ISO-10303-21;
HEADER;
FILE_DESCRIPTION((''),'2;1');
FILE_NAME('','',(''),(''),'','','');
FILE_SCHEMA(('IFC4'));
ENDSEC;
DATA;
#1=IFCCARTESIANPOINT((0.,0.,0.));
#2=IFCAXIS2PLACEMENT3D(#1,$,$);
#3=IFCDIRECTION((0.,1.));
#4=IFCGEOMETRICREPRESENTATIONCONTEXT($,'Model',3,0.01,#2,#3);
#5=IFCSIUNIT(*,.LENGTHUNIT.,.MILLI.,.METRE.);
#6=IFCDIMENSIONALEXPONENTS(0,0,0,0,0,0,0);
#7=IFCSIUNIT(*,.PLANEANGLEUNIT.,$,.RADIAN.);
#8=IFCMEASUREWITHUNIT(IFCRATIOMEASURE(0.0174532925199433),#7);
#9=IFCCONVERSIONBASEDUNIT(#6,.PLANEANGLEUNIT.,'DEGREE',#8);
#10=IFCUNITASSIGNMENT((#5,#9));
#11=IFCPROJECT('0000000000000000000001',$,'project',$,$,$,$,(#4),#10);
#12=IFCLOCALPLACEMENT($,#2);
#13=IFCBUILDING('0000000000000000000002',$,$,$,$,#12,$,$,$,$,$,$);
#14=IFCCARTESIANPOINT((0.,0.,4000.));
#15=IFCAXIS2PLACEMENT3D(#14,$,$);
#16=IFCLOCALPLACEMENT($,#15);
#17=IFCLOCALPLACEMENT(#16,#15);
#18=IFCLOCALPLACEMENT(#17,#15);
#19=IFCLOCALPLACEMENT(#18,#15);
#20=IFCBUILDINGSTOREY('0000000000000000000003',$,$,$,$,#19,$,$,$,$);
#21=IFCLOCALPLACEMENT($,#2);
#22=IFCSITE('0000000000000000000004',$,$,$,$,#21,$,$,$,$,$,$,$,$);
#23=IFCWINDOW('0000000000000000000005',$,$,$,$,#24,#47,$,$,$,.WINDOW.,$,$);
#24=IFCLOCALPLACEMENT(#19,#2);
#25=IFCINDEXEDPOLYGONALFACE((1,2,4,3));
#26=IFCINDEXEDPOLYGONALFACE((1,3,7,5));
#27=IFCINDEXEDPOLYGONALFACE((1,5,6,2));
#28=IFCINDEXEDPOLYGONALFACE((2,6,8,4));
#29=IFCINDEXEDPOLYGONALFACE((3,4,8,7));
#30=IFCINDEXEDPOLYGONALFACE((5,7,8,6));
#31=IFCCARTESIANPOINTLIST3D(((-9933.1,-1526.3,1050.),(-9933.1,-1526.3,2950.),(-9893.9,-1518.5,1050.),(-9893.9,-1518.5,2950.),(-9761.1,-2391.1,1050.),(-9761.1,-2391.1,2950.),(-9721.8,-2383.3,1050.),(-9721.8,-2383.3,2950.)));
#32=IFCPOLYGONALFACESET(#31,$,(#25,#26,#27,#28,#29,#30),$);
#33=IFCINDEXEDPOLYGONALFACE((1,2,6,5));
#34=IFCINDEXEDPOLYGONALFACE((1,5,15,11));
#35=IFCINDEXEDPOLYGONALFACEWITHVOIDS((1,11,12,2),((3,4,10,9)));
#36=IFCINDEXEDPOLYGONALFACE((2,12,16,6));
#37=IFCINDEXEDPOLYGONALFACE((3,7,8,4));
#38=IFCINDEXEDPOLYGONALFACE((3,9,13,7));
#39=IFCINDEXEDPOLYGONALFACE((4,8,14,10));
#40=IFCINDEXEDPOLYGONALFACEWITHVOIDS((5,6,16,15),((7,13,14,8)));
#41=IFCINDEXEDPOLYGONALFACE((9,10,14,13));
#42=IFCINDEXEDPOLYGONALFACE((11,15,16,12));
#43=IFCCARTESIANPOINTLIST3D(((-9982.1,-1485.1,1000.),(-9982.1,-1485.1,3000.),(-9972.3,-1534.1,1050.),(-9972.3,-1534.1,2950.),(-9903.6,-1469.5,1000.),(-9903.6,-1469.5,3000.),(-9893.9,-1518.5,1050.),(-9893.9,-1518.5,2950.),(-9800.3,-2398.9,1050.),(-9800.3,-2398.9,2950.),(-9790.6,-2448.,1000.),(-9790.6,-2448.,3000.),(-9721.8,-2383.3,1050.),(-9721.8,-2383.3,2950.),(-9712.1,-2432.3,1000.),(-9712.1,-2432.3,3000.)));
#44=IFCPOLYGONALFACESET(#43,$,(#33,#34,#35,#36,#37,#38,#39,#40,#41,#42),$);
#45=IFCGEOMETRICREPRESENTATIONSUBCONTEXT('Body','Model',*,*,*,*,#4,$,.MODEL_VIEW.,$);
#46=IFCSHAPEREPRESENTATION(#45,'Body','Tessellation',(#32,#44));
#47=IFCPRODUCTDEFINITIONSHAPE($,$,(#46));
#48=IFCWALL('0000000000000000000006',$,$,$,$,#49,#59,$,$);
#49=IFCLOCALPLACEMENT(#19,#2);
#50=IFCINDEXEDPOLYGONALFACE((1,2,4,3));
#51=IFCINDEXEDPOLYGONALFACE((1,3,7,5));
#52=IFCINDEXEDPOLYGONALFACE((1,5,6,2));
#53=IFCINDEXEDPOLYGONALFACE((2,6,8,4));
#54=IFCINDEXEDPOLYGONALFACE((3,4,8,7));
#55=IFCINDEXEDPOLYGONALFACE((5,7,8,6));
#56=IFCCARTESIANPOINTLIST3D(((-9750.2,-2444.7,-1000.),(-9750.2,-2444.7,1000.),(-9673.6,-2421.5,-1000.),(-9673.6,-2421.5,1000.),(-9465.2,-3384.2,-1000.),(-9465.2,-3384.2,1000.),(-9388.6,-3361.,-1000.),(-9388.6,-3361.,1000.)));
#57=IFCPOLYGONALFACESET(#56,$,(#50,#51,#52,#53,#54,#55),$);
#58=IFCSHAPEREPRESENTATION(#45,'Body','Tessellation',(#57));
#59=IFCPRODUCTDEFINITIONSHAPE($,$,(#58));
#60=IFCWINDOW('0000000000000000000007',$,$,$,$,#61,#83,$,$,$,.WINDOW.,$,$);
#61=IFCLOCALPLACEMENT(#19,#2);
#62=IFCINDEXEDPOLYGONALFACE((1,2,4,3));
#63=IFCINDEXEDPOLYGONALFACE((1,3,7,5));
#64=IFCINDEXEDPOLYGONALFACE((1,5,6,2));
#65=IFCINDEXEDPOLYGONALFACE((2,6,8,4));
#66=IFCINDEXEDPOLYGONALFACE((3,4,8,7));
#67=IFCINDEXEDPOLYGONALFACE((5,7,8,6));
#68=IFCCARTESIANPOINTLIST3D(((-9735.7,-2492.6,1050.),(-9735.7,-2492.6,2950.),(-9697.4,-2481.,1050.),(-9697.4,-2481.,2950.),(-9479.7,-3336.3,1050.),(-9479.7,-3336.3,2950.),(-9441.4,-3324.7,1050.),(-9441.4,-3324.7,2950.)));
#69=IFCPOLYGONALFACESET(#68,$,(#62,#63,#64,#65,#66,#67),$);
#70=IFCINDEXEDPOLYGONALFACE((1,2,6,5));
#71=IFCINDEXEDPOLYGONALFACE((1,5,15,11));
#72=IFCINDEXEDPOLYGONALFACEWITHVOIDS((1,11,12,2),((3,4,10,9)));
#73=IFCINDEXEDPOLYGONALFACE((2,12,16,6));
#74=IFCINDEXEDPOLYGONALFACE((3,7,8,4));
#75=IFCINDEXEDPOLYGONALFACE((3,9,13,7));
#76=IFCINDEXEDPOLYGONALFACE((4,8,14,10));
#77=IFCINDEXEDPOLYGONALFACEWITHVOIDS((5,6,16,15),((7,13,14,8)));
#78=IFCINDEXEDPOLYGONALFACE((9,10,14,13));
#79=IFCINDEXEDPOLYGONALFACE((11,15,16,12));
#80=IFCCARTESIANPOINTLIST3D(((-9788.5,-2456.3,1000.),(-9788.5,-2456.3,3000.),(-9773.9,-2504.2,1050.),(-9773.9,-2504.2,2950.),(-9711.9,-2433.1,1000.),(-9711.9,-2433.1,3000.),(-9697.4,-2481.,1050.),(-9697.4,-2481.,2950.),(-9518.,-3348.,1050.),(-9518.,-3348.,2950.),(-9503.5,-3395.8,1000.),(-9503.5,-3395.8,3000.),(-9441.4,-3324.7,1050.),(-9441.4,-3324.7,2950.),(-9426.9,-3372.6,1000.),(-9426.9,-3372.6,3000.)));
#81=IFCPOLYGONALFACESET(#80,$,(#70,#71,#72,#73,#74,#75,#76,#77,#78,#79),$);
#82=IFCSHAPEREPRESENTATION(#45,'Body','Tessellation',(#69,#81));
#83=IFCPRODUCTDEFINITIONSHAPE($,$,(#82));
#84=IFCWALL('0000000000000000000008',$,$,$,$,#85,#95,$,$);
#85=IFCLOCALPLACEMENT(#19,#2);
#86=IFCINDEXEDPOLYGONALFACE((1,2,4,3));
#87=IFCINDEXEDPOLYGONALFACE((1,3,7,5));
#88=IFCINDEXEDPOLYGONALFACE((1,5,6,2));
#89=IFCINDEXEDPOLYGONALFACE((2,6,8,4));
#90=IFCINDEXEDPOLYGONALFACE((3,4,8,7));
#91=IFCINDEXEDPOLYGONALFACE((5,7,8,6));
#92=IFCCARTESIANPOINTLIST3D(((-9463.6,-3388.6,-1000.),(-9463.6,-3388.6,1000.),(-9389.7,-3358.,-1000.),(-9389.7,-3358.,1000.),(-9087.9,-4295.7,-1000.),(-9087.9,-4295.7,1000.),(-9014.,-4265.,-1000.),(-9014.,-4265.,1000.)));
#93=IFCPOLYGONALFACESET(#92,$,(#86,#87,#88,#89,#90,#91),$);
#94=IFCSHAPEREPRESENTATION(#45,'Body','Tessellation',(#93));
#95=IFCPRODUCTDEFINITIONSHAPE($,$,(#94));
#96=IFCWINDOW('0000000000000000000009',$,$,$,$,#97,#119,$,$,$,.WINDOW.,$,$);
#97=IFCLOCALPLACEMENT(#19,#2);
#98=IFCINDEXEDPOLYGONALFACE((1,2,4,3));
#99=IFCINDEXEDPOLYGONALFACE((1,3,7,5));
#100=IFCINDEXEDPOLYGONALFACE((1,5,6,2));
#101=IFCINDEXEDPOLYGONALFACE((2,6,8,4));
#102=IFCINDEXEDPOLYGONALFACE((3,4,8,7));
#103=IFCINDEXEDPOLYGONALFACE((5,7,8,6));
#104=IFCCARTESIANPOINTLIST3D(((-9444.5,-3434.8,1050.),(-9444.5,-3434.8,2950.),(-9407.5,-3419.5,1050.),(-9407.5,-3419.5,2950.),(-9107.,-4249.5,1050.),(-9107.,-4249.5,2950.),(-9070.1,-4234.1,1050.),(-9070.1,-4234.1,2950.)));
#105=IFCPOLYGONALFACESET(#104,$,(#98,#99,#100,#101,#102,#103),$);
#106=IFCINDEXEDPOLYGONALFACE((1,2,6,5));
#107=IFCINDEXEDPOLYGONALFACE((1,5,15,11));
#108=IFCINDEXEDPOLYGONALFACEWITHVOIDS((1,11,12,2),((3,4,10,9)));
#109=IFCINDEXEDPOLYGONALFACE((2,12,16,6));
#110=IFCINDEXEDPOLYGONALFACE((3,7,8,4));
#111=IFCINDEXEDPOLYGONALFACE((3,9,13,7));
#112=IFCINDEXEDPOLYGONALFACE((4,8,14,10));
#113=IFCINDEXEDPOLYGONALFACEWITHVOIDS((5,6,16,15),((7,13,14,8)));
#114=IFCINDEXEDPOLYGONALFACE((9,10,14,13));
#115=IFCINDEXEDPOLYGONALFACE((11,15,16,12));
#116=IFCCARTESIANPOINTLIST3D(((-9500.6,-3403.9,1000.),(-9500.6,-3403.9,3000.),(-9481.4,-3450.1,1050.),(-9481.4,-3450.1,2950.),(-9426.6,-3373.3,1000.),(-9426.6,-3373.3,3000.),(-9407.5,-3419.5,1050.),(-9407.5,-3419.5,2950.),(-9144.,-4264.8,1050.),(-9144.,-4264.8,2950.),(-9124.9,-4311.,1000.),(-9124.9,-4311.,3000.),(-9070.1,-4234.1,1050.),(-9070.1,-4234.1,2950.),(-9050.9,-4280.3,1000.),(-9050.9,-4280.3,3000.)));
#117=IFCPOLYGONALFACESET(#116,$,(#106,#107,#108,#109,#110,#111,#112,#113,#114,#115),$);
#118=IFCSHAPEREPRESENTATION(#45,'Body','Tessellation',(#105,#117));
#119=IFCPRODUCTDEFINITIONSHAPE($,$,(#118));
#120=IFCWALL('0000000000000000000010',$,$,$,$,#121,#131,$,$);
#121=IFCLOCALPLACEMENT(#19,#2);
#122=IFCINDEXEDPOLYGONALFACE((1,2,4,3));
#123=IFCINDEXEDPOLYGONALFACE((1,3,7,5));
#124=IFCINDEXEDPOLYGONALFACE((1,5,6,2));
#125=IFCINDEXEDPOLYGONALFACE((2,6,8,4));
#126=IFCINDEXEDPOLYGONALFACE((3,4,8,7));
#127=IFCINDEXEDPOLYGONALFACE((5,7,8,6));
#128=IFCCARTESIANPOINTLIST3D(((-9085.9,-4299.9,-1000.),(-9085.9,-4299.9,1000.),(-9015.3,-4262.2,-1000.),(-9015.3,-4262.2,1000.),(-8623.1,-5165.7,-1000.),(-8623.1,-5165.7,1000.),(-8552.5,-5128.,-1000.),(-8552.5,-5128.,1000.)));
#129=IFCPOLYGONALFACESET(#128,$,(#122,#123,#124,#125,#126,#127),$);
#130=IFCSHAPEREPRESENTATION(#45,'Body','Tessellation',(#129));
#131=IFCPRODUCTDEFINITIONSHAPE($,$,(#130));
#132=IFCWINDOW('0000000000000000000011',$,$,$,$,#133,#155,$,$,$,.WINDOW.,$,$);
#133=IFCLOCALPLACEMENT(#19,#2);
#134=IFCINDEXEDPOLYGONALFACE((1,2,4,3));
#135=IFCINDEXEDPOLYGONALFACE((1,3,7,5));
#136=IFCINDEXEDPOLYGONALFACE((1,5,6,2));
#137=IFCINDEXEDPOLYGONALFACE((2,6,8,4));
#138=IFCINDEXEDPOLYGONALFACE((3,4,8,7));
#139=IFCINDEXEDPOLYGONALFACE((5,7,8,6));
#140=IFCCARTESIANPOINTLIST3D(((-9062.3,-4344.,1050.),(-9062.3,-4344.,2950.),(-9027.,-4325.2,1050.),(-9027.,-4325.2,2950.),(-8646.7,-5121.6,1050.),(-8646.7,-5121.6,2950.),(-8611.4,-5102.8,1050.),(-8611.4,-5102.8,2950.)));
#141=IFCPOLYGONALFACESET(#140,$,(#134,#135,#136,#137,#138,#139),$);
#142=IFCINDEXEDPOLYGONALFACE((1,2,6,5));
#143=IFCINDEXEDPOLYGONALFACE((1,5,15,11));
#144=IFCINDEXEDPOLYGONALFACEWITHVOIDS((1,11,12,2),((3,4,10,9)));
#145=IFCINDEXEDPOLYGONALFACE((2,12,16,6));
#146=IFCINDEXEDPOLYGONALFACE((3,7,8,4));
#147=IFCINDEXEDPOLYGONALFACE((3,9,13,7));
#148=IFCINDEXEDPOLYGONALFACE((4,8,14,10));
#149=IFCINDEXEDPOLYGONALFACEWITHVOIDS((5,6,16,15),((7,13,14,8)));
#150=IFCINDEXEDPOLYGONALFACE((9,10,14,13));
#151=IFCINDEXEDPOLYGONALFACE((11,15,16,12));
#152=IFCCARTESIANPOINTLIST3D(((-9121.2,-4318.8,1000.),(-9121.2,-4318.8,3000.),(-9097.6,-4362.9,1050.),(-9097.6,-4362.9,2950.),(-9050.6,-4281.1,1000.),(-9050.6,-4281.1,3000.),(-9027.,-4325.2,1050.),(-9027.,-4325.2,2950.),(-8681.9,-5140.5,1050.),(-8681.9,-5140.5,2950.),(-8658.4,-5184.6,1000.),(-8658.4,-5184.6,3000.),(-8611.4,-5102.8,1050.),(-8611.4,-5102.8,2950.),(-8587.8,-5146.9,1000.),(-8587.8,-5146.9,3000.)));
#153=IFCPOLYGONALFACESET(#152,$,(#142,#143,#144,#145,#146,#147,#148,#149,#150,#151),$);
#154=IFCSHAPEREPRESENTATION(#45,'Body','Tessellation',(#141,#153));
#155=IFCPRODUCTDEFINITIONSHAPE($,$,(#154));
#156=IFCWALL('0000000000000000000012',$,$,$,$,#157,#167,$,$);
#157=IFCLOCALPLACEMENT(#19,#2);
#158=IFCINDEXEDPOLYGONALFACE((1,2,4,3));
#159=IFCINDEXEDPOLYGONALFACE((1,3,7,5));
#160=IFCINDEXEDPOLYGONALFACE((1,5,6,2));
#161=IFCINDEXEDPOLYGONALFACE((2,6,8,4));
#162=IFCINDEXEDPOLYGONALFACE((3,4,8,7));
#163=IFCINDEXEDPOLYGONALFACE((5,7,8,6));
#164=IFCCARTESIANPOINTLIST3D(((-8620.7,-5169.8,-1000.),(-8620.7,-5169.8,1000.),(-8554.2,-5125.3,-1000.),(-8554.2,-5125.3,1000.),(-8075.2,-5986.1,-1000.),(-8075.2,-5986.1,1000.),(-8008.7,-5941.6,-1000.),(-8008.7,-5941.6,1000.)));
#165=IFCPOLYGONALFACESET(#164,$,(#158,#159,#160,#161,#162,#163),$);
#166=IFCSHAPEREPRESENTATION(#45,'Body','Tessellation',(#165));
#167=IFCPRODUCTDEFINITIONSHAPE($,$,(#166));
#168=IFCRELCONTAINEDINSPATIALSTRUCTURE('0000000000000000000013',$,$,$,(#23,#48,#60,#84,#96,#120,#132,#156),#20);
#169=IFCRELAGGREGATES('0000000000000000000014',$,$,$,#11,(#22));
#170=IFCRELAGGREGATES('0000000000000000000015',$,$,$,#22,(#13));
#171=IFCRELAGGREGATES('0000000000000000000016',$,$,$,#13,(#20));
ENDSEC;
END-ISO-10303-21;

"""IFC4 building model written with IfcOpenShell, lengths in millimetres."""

from ifc_helpers import new_model, entity, si_unit, converted_unit, direction, frame, origin, origin_2d, place, context, subcontext, project, spatial, rectangle, extrude, element, save


model = new_model("IFC4")

# Units and contexts
model_context = context("Model", 3, precision=0.01, world=origin(), true_north=direction((0.0, 1.0)))
body_context = subcontext(model_context, "Body", "Model", "MODEL_VIEW")
ifc_project = project(units=[si_unit("LENGTHUNIT", "METRE", prefix="MILLI"), converted_unit("PLANEANGLEUNIT", "DEGREE", entity("IfcRatioMeasure", 0.0174532925199433), si_unit("PLANEANGLEUNIT", "RADIAN"), dimensions=[0, 0, 0, 0, 0, 0, 0])], contexts=[model_context])

# Site, building, storey
site_placement = place(None, origin())
site = spatial("IfcSite", under=ifc_project, at=site_placement)
building_placement = place(None, origin())
building = spatial("IfcBuilding", under=site, at=building_placement)
placement_1 = place(None, frame((0.0, 0.0, 4000.0)))
placement_2 = place(placement_1, frame((0.0, 0.0, 4000.0)))
placement_3 = place(placement_2, frame((0.0, 0.0, 4000.0)))
storey_placement = place(placement_3, frame((0.0, 0.0, 4000.0)))
storey = spatial("IfcBuildingStorey", under=building, at=storey_placement)

# Shared definitions
cartesian_point_1 = entity("IfcCartesianPoint", [-440.9, -950.0])
shared_polyline = entity("IfcPolyline", [cartesian_point_1, entity("IfcCartesianPoint", [-440.9, 950.0]), entity("IfcCartesianPoint", [-440.9, 950.0]), entity("IfcCartesianPoint", [440.9, 950.0]), entity("IfcCartesianPoint", [440.9, 950.0]), entity("IfcCartesianPoint", [440.9, -950.0]), entity("IfcCartesianPoint", [440.9, -950.0]), entity("IfcCartesianPoint", [-440.9, -950.0]), cartesian_point_1])

# Window
window_1_placement = place(storey_placement, frame((-9807.9, -1950.9, 2000.0), z_axis=(0.0, 0.0, 1.0), x_axis=(1950.902524, -9807.852943, 0.0)))
cartesian_point_2 = entity("IfcCartesianPoint", [-490.9, -1000.0])
element("IfcWindow", 1, at=window_1_placement, inside=storey, PredefinedType="WINDOW", context=body_context, shape_type="SweptSolid", body=[
    entity("IfcExtrudedAreaSolid", entity("IfcArbitraryClosedProfileDef", "AREA", None, shared_polyline), entity("IfcAxis2Placement3D", entity("IfcCartesianPoint", [0.0, 0.0, 0.0]), entity("IfcDirection", [0.0, -1.0, 0.0]), entity("IfcDirection", [1.0, 0.0, 0.0])), entity("IfcDirection", [0.0, 0.0, 1.0]), 40.0),
    entity("IfcExtrudedAreaSolid", entity("IfcArbitraryProfileDefWithVoids", "AREA", None, entity("IfcPolyline", [cartesian_point_2, entity("IfcCartesianPoint", [-490.9, 1000.0]), entity("IfcCartesianPoint", [-490.9, 1000.0]), entity("IfcCartesianPoint", [490.9, 1000.0]), entity("IfcCartesianPoint", [490.9, 1000.0]), entity("IfcCartesianPoint", [490.9, -1000.0]), entity("IfcCartesianPoint", [490.9, -1000.0]), entity("IfcCartesianPoint", [-490.9, -1000.0]), cartesian_point_2]), [shared_polyline]), entity("IfcAxis2Placement3D", entity("IfcCartesianPoint", [0.0, 0.0, 0.0]), entity("IfcDirection", [0.0, -1.0, 0.0]), entity("IfcDirection", [1.0, 0.0, 0.0])), entity("IfcDirection", [0.0, 0.0, 1.0]), 80.0),
])

# Wall
wall_1_placement = place(storey_placement, frame((-9569.4, -2902.8, -1000.0), z_axis=(0.0, 0.0, 1.0), x_axis=(2902.846475, -9569.403447, 0.0)))
element("IfcWall", 2, at=wall_1_placement, inside=storey, context=body_context, shape_type="SweptSolid", body=[
    extrude(rectangle(XDim=981.7, YDim=80.0, at=origin_2d()), origin(), (0.0, 0.0, 1.0), 2000.0),
])

# Window
window_2_placement = place(storey_placement, frame((-9569.4, -2902.8, 2000.0), z_axis=(0.0, 0.0, 1.0), x_axis=(2902.846475, -9569.403447, 0.0)))
cartesian_point_3 = entity("IfcCartesianPoint", [-490.9, -1000.0])
element("IfcWindow", 3, at=window_2_placement, inside=storey, PredefinedType="WINDOW", context=body_context, shape_type="SweptSolid", body=[
    entity("IfcExtrudedAreaSolid", entity("IfcArbitraryClosedProfileDef", "AREA", None, shared_polyline), entity("IfcAxis2Placement3D", entity("IfcCartesianPoint", [0.0, 0.0, 0.0]), entity("IfcDirection", [0.0, -1.0, 0.0]), entity("IfcDirection", [1.0, 0.0, 0.0])), entity("IfcDirection", [0.0, 0.0, 1.0]), 40.0),
    entity("IfcExtrudedAreaSolid", entity("IfcArbitraryProfileDefWithVoids", "AREA", None, entity("IfcPolyline", [cartesian_point_3, entity("IfcCartesianPoint", [-490.9, 1000.0]), entity("IfcCartesianPoint", [-490.9, 1000.0]), entity("IfcCartesianPoint", [490.9, 1000.0]), entity("IfcCartesianPoint", [490.9, 1000.0]), entity("IfcCartesianPoint", [490.9, -1000.0]), entity("IfcCartesianPoint", [490.9, -1000.0]), entity("IfcCartesianPoint", [-490.9, -1000.0]), cartesian_point_3]), [shared_polyline]), entity("IfcAxis2Placement3D", entity("IfcCartesianPoint", [0.0, 0.0, 0.0]), entity("IfcDirection", [0.0, -1.0, 0.0]), entity("IfcDirection", [1.0, 0.0, 0.0])), entity("IfcDirection", [0.0, 0.0, 1.0]), 80.0),
])

# Wall
wall_2_placement = place(storey_placement, frame((-9238.8, -3826.8, -1000.0), z_axis=(0.0, 0.0, 1.0), x_axis=(3826.834406, -9238.795291, 0.0)))
element("IfcWall", 4, at=wall_2_placement, inside=storey, context=body_context, shape_type="SweptSolid", body=[
    extrude(rectangle(XDim=981.7, YDim=80.0, at=origin_2d()), origin(), (0.0, 0.0, 1.0), 2000.0),
])

# Window
window_3_placement = place(storey_placement, frame((-9238.8, -3826.8, 2000.0), z_axis=(0.0, 0.0, 1.0), x_axis=(3826.834406, -9238.795291, 0.0)))
cartesian_point_4 = entity("IfcCartesianPoint", [-490.9, -1000.0])
element("IfcWindow", 5, at=window_3_placement, inside=storey, PredefinedType="WINDOW", context=body_context, shape_type="SweptSolid", body=[
    entity("IfcExtrudedAreaSolid", entity("IfcArbitraryClosedProfileDef", "AREA", None, shared_polyline), entity("IfcAxis2Placement3D", entity("IfcCartesianPoint", [0.0, 0.0, 0.0]), entity("IfcDirection", [0.0, -1.0, 0.0]), entity("IfcDirection", [1.0, 0.0, 0.0])), entity("IfcDirection", [0.0, 0.0, 1.0]), 40.0),
    entity("IfcExtrudedAreaSolid", entity("IfcArbitraryProfileDefWithVoids", "AREA", None, entity("IfcPolyline", [cartesian_point_4, entity("IfcCartesianPoint", [-490.9, 1000.0]), entity("IfcCartesianPoint", [-490.9, 1000.0]), entity("IfcCartesianPoint", [490.9, 1000.0]), entity("IfcCartesianPoint", [490.9, 1000.0]), entity("IfcCartesianPoint", [490.9, -1000.0]), entity("IfcCartesianPoint", [490.9, -1000.0]), entity("IfcCartesianPoint", [-490.9, -1000.0]), cartesian_point_4]), [shared_polyline]), entity("IfcAxis2Placement3D", entity("IfcCartesianPoint", [0.0, 0.0, 0.0]), entity("IfcDirection", [0.0, -1.0, 0.0]), entity("IfcDirection", [1.0, 0.0, 0.0])), entity("IfcDirection", [0.0, 0.0, 1.0]), 80.0),
])

# Wall
wall_3_placement = place(storey_placement, frame((-8819.2, -4714.0, -1000.0), z_axis=(0.0, 0.0, 1.0), x_axis=(4713.9678, -8819.212413, 0.0)))
element("IfcWall", 6, at=wall_3_placement, inside=storey, context=body_context, shape_type="SweptSolid", body=[
    extrude(rectangle(XDim=981.7, YDim=80.0, at=origin_2d()), origin(), (0.0, 0.0, 1.0), 2000.0),
])

# Window
window_4_placement = place(storey_placement, frame((-8819.2, -4714.0, 2000.0), z_axis=(0.0, 0.0, 1.0), x_axis=(4713.9678, -8819.212413, 0.0)))
cartesian_point_5 = entity("IfcCartesianPoint", [-490.9, -1000.0])
element("IfcWindow", 7, at=window_4_placement, inside=storey, PredefinedType="WINDOW", context=body_context, shape_type="SweptSolid", body=[
    entity("IfcExtrudedAreaSolid", entity("IfcArbitraryClosedProfileDef", "AREA", None, shared_polyline), entity("IfcAxis2Placement3D", entity("IfcCartesianPoint", [0.0, 0.0, 0.0]), entity("IfcDirection", [0.0, -1.0, 0.0]), entity("IfcDirection", [1.0, 0.0, 0.0])), entity("IfcDirection", [0.0, 0.0, 1.0]), 40.0),
    entity("IfcExtrudedAreaSolid", entity("IfcArbitraryProfileDefWithVoids", "AREA", None, entity("IfcPolyline", [cartesian_point_5, entity("IfcCartesianPoint", [-490.9, 1000.0]), entity("IfcCartesianPoint", [-490.9, 1000.0]), entity("IfcCartesianPoint", [490.9, 1000.0]), entity("IfcCartesianPoint", [490.9, 1000.0]), entity("IfcCartesianPoint", [490.9, -1000.0]), entity("IfcCartesianPoint", [490.9, -1000.0]), entity("IfcCartesianPoint", [-490.9, -1000.0]), cartesian_point_5]), [shared_polyline]), entity("IfcAxis2Placement3D", entity("IfcCartesianPoint", [0.0, 0.0, 0.0]), entity("IfcDirection", [0.0, -1.0, 0.0]), entity("IfcDirection", [1.0, 0.0, 0.0])), entity("IfcDirection", [0.0, 0.0, 1.0]), 80.0),
])

# Wall
wall_4_placement = place(storey_placement, frame((-8314.7, -5555.7, -1000.0), z_axis=(0.0, 0.0, 1.0), x_axis=(5555.703069, -8314.695629, 0.0)))
element("IfcWall", 8, at=wall_4_placement, inside=storey, context=body_context, shape_type="SweptSolid", body=[
    extrude(rectangle(XDim=981.7, YDim=80.0, at=origin_2d()), origin(), (0.0, 0.0, 1.0), 2000.0),
])

save(model, "model.ifc")
